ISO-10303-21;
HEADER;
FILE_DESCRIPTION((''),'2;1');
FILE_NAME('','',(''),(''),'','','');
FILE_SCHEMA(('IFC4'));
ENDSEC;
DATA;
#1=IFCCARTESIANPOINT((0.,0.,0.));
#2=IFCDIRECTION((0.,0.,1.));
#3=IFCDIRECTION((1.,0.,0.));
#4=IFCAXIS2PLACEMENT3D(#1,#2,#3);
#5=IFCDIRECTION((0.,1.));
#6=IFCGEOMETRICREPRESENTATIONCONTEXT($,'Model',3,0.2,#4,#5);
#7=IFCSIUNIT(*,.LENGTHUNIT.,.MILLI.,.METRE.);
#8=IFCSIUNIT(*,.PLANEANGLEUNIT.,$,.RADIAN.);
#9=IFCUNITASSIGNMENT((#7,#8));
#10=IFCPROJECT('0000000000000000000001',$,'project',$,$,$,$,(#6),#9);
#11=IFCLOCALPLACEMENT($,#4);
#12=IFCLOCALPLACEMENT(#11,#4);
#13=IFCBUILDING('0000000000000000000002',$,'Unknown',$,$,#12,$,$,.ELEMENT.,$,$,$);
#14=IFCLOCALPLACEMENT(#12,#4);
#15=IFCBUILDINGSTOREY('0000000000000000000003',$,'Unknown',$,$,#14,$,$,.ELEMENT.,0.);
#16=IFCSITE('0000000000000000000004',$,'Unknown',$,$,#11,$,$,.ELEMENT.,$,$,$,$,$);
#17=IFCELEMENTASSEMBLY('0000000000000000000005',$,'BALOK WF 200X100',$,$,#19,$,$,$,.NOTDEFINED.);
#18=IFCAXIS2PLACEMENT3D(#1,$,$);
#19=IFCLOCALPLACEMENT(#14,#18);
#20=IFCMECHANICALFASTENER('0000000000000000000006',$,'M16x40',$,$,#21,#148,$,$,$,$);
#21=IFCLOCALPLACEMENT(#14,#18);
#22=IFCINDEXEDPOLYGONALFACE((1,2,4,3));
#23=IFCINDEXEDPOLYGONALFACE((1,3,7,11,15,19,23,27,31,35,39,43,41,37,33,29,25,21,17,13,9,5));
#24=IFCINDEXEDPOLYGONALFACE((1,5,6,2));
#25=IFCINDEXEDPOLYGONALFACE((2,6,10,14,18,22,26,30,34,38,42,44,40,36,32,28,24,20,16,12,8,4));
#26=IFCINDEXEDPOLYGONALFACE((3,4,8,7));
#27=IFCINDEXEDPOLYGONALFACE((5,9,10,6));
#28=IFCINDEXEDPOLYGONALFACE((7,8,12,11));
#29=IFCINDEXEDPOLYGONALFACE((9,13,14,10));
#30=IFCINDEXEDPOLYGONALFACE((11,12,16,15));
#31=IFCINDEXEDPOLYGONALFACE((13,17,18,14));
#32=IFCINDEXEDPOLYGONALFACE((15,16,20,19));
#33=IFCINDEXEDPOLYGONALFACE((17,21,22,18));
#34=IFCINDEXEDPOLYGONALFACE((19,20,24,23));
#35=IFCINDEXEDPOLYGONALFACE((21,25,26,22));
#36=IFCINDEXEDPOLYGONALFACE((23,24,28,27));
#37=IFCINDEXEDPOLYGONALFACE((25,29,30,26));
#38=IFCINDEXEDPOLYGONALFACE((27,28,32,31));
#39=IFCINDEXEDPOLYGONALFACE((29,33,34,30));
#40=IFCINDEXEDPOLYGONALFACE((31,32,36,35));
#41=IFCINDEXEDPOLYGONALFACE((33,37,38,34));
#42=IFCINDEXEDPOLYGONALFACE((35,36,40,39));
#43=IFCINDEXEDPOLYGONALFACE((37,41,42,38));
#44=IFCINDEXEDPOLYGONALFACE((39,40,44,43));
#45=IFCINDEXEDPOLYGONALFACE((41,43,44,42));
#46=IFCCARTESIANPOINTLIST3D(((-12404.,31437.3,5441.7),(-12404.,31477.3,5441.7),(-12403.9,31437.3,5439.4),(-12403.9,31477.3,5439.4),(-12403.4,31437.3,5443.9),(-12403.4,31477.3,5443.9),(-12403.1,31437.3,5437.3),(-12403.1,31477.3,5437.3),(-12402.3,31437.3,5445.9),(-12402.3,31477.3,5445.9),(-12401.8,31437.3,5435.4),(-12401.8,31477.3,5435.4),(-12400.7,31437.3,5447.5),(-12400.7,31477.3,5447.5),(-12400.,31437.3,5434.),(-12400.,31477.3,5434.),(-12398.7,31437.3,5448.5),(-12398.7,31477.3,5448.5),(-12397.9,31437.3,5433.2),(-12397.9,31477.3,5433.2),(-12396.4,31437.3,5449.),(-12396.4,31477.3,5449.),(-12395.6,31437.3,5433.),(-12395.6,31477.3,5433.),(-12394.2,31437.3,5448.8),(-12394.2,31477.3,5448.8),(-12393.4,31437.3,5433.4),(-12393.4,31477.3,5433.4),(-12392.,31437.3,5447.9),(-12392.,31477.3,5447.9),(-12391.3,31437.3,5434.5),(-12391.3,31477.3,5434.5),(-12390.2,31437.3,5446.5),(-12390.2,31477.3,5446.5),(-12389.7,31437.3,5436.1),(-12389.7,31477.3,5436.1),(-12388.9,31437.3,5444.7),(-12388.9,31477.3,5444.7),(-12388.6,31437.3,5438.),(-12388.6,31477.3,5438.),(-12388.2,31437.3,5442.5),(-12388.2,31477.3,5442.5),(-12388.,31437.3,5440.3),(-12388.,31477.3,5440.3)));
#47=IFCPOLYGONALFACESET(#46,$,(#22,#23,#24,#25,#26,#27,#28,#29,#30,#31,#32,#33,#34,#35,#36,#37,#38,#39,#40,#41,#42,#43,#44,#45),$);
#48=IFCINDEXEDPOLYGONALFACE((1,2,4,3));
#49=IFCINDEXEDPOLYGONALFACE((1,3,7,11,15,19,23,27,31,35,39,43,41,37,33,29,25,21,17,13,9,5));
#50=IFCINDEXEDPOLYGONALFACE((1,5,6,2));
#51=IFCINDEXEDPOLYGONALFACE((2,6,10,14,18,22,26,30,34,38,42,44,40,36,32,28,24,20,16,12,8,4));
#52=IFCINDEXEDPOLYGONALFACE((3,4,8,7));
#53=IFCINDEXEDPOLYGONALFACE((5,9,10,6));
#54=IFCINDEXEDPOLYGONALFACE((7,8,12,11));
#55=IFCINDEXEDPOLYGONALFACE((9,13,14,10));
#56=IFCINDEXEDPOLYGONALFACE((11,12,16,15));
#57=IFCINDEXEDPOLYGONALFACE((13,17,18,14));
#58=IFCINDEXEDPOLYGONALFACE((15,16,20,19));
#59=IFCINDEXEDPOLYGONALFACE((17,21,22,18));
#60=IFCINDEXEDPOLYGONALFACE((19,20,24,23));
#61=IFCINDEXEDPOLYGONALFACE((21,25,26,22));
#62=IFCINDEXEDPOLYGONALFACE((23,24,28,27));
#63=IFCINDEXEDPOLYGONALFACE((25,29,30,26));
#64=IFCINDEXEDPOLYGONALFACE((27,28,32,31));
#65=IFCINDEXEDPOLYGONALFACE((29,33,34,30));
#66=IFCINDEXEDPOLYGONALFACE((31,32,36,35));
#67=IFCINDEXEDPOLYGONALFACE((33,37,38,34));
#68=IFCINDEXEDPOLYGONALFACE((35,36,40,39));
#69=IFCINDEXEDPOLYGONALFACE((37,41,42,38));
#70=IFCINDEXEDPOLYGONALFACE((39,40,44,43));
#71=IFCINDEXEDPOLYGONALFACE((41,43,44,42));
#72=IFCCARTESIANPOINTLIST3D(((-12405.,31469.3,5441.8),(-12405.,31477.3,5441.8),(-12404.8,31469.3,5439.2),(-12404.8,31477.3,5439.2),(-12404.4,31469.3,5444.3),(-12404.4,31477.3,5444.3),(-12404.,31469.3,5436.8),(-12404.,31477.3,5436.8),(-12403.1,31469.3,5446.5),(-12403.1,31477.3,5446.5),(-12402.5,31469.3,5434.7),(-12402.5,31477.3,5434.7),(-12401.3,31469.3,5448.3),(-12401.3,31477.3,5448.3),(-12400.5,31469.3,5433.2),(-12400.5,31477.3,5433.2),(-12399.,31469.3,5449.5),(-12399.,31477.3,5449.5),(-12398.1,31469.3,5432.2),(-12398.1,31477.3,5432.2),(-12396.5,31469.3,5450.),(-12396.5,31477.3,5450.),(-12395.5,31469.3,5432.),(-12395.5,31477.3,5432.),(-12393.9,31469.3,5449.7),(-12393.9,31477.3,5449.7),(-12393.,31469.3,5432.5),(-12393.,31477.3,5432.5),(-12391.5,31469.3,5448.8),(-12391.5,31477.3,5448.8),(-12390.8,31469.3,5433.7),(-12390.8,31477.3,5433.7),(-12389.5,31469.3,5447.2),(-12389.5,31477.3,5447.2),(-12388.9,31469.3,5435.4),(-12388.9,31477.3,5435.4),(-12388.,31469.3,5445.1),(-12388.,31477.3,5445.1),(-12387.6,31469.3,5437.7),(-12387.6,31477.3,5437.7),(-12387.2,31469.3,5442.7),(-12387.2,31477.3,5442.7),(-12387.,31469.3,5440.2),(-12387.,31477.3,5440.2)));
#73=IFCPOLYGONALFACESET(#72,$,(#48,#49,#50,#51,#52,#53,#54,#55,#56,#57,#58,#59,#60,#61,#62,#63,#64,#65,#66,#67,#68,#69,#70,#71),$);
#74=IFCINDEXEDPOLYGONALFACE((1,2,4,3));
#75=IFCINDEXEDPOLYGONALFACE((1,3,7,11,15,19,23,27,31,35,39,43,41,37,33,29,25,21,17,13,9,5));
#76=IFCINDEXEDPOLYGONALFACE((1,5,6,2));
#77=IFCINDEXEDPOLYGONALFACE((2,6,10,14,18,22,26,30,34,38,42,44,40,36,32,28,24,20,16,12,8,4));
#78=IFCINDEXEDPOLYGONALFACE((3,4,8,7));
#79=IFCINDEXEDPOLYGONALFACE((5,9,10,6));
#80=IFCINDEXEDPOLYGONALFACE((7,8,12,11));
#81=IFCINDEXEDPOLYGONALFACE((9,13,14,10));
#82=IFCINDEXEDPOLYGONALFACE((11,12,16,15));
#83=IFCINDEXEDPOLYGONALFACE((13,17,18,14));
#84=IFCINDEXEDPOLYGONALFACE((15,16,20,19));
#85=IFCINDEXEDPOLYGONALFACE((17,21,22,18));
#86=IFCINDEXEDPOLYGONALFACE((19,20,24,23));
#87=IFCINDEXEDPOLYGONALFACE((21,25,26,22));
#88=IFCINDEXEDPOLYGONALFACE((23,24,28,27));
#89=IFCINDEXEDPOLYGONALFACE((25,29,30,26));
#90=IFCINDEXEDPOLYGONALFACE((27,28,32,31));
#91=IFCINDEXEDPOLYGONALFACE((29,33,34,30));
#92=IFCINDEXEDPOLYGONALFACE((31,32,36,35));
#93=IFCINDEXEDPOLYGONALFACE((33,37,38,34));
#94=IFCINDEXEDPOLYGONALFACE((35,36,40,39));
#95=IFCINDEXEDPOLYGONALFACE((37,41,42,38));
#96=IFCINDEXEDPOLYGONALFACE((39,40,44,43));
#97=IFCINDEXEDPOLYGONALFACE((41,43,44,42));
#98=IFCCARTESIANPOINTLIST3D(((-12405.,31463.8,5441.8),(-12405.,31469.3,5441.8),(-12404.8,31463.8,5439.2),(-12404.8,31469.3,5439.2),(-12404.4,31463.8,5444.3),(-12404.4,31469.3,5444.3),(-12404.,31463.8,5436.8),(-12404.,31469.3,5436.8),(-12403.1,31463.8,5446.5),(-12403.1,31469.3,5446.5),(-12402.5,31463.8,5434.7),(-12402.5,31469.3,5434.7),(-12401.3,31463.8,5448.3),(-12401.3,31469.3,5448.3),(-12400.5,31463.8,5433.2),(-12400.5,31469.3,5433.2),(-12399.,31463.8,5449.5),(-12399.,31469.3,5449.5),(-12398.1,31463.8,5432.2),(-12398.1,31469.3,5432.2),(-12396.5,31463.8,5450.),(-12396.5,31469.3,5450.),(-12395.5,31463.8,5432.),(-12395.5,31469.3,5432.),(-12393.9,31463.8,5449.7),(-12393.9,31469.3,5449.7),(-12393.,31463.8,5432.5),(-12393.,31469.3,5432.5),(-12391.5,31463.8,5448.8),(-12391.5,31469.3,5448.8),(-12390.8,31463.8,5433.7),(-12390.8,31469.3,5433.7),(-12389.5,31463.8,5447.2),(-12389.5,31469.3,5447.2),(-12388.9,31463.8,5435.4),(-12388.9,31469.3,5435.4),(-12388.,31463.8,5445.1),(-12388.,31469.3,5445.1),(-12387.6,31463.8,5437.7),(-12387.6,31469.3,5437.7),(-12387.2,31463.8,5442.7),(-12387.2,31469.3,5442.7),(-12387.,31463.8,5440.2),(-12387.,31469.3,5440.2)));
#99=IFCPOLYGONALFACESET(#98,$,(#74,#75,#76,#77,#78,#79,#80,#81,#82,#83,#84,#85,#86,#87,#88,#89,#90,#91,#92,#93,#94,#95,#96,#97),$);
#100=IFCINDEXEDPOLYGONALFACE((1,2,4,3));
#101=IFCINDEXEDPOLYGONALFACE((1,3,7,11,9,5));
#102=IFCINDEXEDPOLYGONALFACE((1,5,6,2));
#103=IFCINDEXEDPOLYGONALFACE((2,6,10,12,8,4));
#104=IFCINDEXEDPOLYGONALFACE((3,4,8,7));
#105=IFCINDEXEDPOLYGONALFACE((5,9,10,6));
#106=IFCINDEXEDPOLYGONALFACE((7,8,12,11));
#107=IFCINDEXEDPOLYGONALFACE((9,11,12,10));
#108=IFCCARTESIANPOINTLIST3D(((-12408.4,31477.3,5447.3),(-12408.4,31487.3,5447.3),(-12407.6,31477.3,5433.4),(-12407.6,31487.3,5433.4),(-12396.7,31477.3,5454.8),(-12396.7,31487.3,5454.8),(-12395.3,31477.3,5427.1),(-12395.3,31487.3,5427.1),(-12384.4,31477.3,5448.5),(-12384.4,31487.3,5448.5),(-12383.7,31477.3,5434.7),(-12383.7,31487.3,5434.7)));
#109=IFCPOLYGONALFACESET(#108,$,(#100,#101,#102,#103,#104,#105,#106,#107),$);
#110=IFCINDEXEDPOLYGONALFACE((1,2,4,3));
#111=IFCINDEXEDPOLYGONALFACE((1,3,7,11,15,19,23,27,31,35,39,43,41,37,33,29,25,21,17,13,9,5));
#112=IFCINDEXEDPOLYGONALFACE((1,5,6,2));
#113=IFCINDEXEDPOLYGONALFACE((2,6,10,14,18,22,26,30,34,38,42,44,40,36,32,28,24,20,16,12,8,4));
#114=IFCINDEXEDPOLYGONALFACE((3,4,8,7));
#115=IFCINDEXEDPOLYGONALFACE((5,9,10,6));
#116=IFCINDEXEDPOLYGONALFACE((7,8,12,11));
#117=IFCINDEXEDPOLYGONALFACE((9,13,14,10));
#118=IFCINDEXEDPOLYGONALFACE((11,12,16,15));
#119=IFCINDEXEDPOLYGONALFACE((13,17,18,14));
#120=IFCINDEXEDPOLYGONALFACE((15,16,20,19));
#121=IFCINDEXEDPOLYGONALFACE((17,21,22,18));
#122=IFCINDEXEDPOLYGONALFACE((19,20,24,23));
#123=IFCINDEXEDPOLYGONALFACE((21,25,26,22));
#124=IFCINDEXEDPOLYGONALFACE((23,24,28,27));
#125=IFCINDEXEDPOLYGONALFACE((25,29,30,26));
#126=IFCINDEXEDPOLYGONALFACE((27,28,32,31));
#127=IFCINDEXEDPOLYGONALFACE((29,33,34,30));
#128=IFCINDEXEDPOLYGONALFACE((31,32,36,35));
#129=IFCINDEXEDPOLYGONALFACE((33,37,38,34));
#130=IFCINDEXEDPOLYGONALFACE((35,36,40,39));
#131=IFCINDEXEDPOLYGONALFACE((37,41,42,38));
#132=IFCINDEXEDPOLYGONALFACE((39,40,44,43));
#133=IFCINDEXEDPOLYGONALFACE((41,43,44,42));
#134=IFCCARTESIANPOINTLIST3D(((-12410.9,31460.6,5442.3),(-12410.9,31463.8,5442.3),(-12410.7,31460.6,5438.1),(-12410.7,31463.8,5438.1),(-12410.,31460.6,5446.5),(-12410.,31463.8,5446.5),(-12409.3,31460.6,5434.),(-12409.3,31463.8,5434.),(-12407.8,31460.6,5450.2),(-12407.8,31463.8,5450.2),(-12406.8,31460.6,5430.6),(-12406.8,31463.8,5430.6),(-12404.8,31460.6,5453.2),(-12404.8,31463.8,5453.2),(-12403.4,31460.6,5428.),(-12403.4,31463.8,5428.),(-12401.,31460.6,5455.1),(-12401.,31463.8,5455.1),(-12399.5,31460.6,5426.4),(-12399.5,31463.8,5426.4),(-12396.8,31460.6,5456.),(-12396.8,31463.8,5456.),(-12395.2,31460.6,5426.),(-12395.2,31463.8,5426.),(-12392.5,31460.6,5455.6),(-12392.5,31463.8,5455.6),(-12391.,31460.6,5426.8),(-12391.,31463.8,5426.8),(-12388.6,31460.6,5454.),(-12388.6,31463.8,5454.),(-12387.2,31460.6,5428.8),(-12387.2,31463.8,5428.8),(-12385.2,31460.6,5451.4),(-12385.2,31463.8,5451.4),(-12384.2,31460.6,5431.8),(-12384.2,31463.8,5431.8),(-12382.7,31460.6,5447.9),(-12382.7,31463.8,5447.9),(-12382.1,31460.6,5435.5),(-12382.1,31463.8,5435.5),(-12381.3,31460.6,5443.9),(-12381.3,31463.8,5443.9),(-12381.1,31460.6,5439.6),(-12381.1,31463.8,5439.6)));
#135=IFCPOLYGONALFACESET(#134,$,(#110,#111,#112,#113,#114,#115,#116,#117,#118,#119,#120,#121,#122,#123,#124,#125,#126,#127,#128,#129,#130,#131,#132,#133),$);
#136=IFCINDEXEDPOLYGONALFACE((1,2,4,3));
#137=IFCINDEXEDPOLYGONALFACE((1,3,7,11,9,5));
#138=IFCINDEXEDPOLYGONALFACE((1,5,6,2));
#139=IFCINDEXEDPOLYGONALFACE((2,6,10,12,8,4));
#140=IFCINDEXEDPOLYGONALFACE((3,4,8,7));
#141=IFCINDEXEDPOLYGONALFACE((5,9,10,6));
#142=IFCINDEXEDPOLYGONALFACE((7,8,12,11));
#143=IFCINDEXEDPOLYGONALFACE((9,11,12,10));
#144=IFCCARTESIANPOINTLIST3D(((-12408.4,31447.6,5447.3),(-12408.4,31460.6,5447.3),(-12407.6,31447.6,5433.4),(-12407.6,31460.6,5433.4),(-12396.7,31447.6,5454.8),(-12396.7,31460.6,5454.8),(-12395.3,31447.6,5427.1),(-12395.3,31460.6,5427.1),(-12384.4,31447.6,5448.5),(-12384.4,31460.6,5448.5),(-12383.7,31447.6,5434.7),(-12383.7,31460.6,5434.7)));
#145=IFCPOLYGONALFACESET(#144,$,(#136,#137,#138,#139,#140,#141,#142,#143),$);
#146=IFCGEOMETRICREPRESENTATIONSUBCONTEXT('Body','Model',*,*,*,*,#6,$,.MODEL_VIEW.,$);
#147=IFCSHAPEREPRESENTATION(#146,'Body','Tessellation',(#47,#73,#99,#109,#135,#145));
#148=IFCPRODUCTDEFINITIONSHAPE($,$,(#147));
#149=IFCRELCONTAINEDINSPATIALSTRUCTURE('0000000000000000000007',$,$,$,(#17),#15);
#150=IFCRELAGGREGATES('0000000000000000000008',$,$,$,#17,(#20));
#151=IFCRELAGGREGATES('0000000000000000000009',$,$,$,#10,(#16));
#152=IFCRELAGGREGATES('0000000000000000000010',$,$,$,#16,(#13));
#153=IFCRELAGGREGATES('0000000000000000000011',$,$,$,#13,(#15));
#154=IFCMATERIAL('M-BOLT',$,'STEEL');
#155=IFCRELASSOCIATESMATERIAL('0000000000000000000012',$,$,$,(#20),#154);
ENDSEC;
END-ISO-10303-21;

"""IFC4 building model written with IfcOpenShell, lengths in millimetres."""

from ifc_helpers import new_model, si_unit, direction, frame, origin_with_axes, place, context, subcontext, project, spatial, line, arc, indexed_curve, outline, extrude, source, transform, mapped, material, element, aggregate, save


model = new_model("IFC4")

# Units and contexts
model_context = context("Model", 3, precision=0.2, world=origin_with_axes(), true_north=direction((0.0, 1.0)))
body_context = subcontext(model_context, "Body", "Model", "MODEL_VIEW")
ifc_project = project(units=[si_unit("LENGTHUNIT", "METRE", prefix="MILLI"), si_unit("PLANEANGLEUNIT", "RADIAN")], contexts=[model_context])

# Site, building, storey
site_placement = place(None, origin_with_axes())
site = spatial("IfcSite", under=ifc_project, at=site_placement, Name="Unknown", CompositionType="ELEMENT")
building_placement = place(site_placement, origin_with_axes())
building = spatial("IfcBuilding", under=site, at=building_placement, Name="Unknown", CompositionType="ELEMENT")
storey_placement = place(building_placement, origin_with_axes())
storey = spatial("IfcBuildingStorey", under=building, at=storey_placement, Name="Unknown", CompositionType="ELEMENT", Elevation=0.0)

# Element assembly, mechanical fastener
assembly_1_placement = place(storey_placement, frame((-7044.1, 31466.5, 5721.5), z_axis=(0.0, 1.0, 0.0), x_axis=(-0.99863, 0.0, -0.052336)))
assembly_1 = element("IfcElementAssembly", 1, at=assembly_1_placement, inside=storey, Name="BALOK WF 200X100", PredefinedType="NOTDEFINED")
ifc_material_1 = material(Name="M-BOLT", Category="STEEL")
shared_shape_1 = source(origin_with_axes(), body_context, "Body", "SweptSolid", [
    extrude(outline(indexed_curve([(8.0, 0.0), (0.0, 8.0), (-8.0, 0.0), (0.0, -8.0)], segments=[arc(1, 2, 3), arc(3, 4, 1)])), frame((0.0, 0.0, 0.0), z_axis=(0.0, 0.0, -1.0), x_axis=(0.0, 1.0, 0.0)), (0.0, 0.0, 1.0), 40.0),
    extrude(outline(indexed_curve([(9.0, 0.0), (0.0, 9.0), (-9.0, 0.0), (0.0, -9.0)], segments=[arc(1, 2, 3), arc(3, 4, 1)])), frame((0.0, 0.0, 0.0), z_axis=(0.0, 0.0, -1.0), x_axis=(0.0, 1.0, 0.0)), (0.0, 0.0, 1.0), 8.0),
    extrude(outline(indexed_curve([(9.0, 0.0), (0.0, 9.0), (-9.0, 0.0), (0.0, -9.0)], segments=[arc(1, 2, 3), arc(3, 4, 1)])), frame((0.0, 0.0, -8.0), z_axis=(0.0, 0.0, -1.0), x_axis=(0.0, 1.0, 0.0)), (0.0, 0.0, 1.0), 5.5),
    extrude(outline(indexed_curve([(13.9, 0.0), (6.9, 12.0), (-6.9, 12.0), (-13.9, 0.0), (-6.9, -12.0), (6.9, -12.0)], segments=[line(1, 2, 3, 4, 5, 6, 1)])), frame((0.0, 0.0, 10.0), z_axis=(0.0, 0.0, -1.0), x_axis=(0.0, 1.0, 0.0)), (0.0, 0.0, 1.0), 10.0),
    extrude(outline(indexed_curve([(15.0, 0.0), (0.0, 15.0), (-15.0, 0.0), (0.0, -15.0)], segments=[arc(1, 2, 3), arc(3, 4, 1)])), frame((0.0, 0.0, -13.5), z_axis=(0.0, 0.0, -1.0), x_axis=(0.0, 1.0, 0.0)), (0.0, 0.0, 1.0), 3.2),
    extrude(outline(indexed_curve([(13.9, 0.0), (6.9, 12.0), (-6.9, 12.0), (-13.9, 0.0), (-6.9, -12.0), (6.9, -12.0)], segments=[line(1, 2, 3, 4, 5, 6, 1)])), frame((0.0, 0.0, -16.7), z_axis=(0.0, 0.0, -1.0), x_axis=(0.0, 1.0, 0.0)), (0.0, 0.0, 1.0), 13.0),
])
mechanical_fastener_1_placement = place(assembly_1_placement, frame((5359.2, 0.0, 10.7), z_axis=(-0.000004, 0.0, 1.0), x_axis=(-1.0, 0.0, -0.000004)))
mechanical_fastener_1 = element("IfcMechanicalFastener", 2, at=mechanical_fastener_1_placement, material=ifc_material_1, Name="M16x40", context=body_context, shape_type="MappedRepresentation", body=[
    mapped(shared_shape_1, transform((0.0, 0.0, 0.0))),
])
aggregate(assembly_1, [mechanical_fastener_1])

save(model, "model.ifc")
